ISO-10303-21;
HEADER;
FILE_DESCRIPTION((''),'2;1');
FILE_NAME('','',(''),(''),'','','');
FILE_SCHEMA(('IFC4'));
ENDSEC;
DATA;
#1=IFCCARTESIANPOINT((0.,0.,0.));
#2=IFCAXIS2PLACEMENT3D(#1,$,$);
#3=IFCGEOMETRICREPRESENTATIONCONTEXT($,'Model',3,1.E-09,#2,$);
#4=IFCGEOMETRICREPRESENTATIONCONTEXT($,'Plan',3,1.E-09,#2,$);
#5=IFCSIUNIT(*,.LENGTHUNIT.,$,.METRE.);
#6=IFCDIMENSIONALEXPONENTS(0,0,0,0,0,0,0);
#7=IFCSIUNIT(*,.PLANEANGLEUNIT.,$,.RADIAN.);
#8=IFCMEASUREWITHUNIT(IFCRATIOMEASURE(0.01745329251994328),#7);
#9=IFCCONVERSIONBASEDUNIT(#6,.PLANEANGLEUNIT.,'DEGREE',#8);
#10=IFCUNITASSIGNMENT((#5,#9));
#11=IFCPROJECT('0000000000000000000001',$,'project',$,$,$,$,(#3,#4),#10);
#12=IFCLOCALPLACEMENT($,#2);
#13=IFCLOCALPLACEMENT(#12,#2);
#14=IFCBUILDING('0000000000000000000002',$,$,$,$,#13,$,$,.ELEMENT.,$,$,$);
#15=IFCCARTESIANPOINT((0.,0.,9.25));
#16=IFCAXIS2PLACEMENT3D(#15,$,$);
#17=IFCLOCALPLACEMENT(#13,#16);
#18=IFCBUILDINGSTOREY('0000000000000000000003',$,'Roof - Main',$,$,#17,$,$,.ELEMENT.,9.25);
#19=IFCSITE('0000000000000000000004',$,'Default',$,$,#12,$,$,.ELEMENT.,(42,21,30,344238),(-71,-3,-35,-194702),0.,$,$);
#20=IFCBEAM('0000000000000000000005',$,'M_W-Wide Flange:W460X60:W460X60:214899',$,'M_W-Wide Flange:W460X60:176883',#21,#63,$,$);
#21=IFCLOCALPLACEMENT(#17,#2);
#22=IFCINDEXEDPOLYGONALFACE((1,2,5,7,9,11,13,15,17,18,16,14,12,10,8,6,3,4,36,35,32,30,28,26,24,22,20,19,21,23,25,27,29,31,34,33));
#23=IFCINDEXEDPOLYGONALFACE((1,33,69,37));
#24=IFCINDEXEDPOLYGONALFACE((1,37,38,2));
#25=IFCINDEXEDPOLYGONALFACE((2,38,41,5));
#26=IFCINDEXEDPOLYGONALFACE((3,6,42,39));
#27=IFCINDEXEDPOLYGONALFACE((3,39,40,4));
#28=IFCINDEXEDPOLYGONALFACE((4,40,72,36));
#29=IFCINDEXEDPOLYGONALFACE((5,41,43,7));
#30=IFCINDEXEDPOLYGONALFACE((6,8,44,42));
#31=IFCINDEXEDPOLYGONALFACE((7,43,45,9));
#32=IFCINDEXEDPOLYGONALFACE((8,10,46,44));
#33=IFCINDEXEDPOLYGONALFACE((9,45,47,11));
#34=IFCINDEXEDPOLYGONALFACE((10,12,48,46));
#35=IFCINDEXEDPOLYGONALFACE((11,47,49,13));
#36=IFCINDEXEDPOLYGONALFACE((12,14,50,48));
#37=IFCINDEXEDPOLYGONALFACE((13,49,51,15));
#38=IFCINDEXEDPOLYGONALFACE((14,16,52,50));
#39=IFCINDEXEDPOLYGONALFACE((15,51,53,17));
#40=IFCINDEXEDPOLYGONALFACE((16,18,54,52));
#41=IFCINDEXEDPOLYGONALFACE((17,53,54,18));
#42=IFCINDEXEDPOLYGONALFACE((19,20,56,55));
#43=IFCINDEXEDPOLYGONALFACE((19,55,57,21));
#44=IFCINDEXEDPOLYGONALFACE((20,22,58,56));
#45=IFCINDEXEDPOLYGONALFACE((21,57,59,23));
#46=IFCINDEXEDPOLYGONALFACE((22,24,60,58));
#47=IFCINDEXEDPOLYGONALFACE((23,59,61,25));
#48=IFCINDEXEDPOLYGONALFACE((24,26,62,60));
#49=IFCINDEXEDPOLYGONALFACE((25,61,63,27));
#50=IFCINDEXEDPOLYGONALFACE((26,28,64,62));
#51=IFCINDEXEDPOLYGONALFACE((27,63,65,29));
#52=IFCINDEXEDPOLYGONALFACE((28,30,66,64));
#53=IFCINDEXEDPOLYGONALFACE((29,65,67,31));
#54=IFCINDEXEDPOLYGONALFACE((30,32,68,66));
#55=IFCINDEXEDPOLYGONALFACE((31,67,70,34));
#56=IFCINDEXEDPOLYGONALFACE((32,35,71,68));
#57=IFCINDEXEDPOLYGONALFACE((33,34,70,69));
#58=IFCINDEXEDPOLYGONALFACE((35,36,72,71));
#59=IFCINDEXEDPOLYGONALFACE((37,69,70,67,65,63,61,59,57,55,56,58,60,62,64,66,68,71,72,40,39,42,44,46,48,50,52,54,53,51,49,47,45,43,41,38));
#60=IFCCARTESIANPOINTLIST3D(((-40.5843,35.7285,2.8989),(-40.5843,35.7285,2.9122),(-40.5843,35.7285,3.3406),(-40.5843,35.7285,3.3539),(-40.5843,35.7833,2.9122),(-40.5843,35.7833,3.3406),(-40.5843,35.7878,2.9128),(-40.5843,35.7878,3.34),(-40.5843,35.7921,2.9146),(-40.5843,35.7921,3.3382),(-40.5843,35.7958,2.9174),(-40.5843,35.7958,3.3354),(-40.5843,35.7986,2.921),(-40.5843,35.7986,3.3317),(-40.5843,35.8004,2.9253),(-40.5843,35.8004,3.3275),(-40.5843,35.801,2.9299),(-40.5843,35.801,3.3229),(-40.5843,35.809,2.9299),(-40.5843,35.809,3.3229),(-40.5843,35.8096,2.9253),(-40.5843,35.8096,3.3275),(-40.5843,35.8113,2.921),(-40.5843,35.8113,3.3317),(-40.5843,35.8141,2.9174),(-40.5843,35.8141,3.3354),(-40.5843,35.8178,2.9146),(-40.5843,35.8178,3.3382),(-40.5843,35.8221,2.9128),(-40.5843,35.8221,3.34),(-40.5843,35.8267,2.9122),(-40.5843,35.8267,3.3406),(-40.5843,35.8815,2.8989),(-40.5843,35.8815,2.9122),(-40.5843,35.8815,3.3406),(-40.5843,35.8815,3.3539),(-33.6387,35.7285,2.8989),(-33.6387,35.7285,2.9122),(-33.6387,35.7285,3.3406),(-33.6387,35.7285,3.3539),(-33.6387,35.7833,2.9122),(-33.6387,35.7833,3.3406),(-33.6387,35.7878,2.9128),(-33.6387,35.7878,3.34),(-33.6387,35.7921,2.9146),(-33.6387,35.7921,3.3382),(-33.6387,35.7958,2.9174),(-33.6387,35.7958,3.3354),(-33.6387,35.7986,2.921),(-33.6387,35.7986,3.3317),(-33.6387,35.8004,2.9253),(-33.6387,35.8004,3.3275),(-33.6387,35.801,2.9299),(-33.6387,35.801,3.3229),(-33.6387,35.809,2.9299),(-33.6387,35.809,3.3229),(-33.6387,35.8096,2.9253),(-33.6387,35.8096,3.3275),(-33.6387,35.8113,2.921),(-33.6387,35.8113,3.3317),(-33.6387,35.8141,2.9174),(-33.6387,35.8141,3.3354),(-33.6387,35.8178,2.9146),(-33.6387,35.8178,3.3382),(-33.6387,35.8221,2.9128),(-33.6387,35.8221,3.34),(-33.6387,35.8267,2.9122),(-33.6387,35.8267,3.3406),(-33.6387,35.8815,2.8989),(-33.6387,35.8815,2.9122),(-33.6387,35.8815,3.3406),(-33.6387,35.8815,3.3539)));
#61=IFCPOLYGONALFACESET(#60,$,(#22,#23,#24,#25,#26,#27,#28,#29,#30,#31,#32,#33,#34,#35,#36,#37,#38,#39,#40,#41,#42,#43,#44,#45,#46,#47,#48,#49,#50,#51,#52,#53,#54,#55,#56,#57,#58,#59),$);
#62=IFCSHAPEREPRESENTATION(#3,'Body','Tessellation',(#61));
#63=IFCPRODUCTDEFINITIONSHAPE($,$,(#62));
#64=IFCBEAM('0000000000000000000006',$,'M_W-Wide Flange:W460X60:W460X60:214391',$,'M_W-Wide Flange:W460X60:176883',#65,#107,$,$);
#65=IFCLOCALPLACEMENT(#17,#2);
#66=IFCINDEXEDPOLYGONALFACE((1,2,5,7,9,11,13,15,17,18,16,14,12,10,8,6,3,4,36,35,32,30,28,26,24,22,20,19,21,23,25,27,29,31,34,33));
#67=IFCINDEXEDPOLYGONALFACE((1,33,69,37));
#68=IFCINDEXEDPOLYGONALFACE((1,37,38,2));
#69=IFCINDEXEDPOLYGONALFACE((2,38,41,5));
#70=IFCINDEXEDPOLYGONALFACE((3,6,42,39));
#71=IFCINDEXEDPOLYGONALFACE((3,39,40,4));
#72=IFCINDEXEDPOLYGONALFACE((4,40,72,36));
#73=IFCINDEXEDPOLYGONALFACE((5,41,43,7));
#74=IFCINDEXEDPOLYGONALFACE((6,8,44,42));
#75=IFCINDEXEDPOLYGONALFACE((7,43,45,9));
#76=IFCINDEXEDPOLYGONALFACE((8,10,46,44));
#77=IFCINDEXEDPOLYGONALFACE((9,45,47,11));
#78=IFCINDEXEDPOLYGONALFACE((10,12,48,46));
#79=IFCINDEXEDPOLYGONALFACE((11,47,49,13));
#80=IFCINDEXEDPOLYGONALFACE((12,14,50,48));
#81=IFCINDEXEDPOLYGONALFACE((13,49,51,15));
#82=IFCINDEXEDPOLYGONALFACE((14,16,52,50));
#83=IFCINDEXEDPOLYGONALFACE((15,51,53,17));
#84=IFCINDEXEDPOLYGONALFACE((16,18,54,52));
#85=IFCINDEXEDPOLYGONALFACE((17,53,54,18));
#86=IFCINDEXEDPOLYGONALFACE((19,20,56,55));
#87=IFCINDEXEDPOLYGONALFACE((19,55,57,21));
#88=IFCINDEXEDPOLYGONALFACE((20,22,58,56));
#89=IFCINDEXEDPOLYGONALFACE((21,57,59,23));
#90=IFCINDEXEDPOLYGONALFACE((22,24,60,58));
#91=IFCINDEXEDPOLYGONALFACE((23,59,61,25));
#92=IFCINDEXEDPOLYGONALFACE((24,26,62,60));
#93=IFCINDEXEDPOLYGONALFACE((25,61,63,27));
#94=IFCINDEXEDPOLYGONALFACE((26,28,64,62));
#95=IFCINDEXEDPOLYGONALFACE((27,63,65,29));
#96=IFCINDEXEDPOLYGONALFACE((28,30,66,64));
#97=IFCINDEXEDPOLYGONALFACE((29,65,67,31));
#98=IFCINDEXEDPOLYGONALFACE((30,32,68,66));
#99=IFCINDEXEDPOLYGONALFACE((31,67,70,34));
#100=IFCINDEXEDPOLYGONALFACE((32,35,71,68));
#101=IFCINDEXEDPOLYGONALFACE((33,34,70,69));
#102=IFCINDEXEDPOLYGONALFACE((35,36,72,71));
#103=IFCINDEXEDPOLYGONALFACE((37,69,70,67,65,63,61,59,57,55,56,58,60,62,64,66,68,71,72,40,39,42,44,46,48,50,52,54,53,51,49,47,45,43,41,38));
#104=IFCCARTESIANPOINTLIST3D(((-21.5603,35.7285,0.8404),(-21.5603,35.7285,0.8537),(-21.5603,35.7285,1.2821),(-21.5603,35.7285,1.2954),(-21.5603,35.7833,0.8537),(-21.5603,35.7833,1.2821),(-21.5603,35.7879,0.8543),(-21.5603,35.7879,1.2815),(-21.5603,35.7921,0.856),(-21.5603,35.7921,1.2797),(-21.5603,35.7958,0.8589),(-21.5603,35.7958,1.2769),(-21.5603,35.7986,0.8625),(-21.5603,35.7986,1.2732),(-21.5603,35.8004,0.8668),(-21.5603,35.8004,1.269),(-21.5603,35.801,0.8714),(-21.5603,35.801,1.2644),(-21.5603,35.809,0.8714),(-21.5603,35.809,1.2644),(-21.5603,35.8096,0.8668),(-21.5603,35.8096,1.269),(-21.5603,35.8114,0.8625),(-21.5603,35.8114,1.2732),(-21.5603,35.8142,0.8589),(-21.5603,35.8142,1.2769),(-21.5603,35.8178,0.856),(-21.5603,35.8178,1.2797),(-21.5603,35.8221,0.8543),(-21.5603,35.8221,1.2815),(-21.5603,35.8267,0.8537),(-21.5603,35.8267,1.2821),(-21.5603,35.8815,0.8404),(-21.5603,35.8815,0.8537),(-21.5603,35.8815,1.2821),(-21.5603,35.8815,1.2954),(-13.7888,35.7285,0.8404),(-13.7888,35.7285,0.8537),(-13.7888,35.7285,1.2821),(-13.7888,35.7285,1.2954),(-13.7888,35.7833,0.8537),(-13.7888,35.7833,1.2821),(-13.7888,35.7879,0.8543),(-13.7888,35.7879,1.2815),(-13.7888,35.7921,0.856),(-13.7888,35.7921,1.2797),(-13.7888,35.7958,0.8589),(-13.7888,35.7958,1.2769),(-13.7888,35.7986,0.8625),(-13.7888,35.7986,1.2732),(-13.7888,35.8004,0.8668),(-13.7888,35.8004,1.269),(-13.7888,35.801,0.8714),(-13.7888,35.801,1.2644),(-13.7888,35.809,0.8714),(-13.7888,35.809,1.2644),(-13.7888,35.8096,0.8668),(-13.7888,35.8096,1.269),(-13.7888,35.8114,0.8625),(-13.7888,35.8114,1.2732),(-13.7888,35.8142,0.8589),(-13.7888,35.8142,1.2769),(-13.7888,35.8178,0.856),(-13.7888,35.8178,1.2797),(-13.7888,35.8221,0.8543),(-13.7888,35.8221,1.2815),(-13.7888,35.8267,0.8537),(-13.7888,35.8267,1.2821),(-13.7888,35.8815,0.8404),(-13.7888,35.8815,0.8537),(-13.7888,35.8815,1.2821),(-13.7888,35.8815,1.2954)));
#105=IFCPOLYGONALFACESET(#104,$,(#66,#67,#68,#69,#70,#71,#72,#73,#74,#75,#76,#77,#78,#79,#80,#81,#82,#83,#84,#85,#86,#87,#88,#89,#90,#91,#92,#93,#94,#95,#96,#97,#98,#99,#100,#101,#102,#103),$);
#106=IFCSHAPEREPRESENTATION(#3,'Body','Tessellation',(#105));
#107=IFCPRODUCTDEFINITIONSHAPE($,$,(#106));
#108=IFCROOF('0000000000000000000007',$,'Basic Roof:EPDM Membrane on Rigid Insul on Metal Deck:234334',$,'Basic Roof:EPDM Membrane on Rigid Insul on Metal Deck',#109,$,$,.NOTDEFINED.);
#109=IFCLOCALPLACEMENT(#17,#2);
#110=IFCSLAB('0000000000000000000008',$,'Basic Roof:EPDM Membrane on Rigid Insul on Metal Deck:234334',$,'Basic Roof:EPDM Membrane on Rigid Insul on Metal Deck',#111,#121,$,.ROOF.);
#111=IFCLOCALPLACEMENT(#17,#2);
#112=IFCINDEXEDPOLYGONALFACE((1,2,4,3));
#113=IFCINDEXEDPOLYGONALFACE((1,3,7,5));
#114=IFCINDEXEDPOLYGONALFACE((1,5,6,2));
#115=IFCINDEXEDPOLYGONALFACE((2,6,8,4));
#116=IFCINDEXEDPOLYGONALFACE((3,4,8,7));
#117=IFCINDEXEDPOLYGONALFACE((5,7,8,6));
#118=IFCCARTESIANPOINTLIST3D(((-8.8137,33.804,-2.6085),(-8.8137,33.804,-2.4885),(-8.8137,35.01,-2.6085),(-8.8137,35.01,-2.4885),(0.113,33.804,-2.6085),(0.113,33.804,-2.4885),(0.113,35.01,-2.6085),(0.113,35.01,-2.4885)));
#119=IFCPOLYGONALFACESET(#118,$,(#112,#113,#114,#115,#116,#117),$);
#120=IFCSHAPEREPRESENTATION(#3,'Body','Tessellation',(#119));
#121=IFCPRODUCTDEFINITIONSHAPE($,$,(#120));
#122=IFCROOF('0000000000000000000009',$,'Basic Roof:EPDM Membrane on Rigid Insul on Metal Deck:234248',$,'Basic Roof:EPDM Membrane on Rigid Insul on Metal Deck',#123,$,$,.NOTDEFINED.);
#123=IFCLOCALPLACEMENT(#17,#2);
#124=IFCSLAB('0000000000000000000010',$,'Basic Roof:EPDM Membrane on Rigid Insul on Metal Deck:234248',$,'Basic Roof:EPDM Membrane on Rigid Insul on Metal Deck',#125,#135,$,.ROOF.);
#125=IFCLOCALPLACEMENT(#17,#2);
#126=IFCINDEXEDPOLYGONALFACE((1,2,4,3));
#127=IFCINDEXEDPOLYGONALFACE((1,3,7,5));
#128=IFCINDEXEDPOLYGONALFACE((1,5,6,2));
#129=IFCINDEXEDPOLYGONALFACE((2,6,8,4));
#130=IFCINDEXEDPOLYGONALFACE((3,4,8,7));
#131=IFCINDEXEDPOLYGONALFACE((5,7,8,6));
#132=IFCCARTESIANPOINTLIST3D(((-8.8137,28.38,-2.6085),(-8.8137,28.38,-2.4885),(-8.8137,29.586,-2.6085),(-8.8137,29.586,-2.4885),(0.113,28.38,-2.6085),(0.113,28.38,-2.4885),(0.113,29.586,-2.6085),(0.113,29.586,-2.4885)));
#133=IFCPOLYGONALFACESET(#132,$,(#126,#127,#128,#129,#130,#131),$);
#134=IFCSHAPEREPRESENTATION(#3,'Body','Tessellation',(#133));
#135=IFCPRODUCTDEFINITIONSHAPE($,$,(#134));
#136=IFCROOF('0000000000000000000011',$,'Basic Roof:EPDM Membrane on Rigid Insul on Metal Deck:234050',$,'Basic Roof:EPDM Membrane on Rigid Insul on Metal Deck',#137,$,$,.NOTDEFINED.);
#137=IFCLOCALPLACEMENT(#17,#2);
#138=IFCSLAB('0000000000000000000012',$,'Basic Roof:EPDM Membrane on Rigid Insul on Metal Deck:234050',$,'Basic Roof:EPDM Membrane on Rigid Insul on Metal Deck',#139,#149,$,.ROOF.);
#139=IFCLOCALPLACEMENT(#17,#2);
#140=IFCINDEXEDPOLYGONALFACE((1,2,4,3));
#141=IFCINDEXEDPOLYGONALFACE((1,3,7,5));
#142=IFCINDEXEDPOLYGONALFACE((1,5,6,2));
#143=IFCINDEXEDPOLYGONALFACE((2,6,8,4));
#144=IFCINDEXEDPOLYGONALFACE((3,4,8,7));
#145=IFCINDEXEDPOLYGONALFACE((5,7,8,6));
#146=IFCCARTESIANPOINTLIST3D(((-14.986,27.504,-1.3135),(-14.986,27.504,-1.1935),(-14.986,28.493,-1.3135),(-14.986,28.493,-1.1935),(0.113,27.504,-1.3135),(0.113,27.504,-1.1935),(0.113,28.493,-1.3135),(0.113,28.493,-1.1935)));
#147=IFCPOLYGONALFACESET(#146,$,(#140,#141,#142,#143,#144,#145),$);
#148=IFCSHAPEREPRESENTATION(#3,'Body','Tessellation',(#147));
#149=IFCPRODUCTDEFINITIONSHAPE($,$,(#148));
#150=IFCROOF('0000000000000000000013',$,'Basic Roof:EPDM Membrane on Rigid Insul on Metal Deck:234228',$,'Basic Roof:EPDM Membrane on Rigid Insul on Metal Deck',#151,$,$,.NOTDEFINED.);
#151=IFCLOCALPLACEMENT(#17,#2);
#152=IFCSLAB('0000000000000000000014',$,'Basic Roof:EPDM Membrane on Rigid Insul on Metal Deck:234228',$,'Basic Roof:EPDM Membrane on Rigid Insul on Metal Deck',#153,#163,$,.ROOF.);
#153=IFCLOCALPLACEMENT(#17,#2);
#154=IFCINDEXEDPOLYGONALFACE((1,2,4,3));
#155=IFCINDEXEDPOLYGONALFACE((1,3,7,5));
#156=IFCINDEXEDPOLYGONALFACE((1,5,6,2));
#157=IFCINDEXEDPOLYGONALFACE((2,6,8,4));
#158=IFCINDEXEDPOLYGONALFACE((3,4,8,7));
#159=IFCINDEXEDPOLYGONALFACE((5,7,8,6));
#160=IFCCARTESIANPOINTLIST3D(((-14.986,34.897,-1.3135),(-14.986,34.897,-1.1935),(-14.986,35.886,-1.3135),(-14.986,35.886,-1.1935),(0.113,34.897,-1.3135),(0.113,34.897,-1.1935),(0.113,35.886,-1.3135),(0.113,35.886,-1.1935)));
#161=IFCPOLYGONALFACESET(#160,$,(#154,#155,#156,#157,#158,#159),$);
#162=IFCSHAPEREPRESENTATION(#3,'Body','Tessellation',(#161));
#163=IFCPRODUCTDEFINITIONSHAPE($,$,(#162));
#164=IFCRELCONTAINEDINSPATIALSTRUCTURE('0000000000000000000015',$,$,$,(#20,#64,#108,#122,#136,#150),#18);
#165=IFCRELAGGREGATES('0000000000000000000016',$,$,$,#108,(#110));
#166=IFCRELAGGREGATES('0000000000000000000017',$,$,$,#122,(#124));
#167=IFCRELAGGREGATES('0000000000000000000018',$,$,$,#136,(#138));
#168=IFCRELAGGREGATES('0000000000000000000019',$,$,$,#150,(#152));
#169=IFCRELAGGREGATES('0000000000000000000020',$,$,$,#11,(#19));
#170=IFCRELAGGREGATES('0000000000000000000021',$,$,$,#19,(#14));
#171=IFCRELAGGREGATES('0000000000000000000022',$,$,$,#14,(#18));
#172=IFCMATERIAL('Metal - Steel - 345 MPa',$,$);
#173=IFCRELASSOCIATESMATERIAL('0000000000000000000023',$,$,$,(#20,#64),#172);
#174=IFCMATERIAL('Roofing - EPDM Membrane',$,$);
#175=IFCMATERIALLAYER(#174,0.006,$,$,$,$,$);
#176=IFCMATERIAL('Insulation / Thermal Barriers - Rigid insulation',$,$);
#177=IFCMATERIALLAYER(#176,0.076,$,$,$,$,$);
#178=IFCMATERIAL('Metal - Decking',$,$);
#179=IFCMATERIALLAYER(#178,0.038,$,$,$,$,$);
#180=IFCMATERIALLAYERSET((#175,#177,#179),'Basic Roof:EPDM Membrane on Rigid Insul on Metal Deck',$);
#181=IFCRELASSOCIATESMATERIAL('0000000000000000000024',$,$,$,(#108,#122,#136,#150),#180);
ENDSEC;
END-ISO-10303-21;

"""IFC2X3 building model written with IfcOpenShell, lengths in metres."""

from ifc_helpers import new_model, entity, si_unit, converted_unit, frame, frame_2d, origin, origin_2d_with_axis, place, context, project, spatial, polyline, circle_curve, parameter, trimmed, segment, composite_curve, rectangle, outline, extrude, material, layer, layer_set, layer_usage, element, aggregate, save


model = new_model("IFC2X3")

# Units and contexts
model_context = context("Model", 3, precision=1e-09, world=origin())
plan_context = context("Plan", 3, precision=1e-09, world=origin())
ifc_project = project(units=[si_unit("LENGTHUNIT", "METRE"), converted_unit("PLANEANGLEUNIT", "DEGREE", entity("IfcRatioMeasure", 0.01745329251994328), si_unit("PLANEANGLEUNIT", "RADIAN"), dimensions=[0, 0, 0, 0, 0, 0, 0])], contexts=[model_context, plan_context])

# Site, building, storey
site_placement = place(None, origin())
site = spatial("IfcSite", under=ifc_project, at=site_placement, Name="Default", CompositionType="ELEMENT", RefLatitude=(42, 21, 30, 344238), RefLongitude=(-71, -3, -35, -194702), RefElevation=0.0)
building_placement = place(site_placement, origin())
building = spatial("IfcBuilding", under=site, at=building_placement, CompositionType="ELEMENT")
storey_placement = place(building_placement, frame((0.0, 0.0, 9.25)))
storey = spatial("IfcBuildingStorey", under=building, at=storey_placement, Name="Roof - Main", CompositionType="ELEMENT", Elevation=9.25)

# Shared definitions
ifc_material_1 = material(Name="Metal - Steel - 345 MPa")

# Beams
beam_1_placement = place(storey_placement, frame((-6.691, 35.805, 3.3539), z_axis=(0.0, 0.0, 1.0), x_axis=(0.0, -1.0, 0.0)))
element("IfcBeam", 1, at=beam_1_placement, inside=storey, material=ifc_material_1, Name="M_W-Wide Flange:W460X60:W460X60:214899", ObjectType="M_W-Wide Flange:W460X60:176883", context=model_context, shape_type="SweptSolid", body=[
    extrude(outline(composite_curve([segment(polyline([(-0.0765, -0.2142), (-0.0765, -0.2275)]), True, "CONTINUOUS"), segment(polyline([(-0.0765, -0.2275), (0.0765, -0.2275)]), True, "CONTINUOUS"), segment(polyline([(0.0765, -0.2275), (0.0765, -0.2142)]), True, "CONTINUOUS"), segment(polyline([(0.0765, -0.2142), (0.0217, -0.2142)]), True, "CONTINUOUS"), segment(trimmed(circle_curve(frame_2d((0.0217, -0.1965), x_axis=(1.0, 0.0)), 0.0177), [parameter(180.0)], [parameter(270.0)], True, "PARAMETER"), False, "CONTINUOUS"), segment(polyline([(0.004, -0.1965), (0.004, 0.1965)]), True, "CONTINUOUS"), segment(trimmed(circle_curve(frame_2d((0.0217, 0.1965), x_axis=(1.0, 0.0)), 0.0177), [parameter(90.0)], [parameter(180.0)], True, "PARAMETER"), False, "CONTINUOUS"), segment(polyline([(0.0217, 0.2142), (0.0765, 0.2142)]), True, "CONTINUOUS"), segment(polyline([(0.0765, 0.2142), (0.0765, 0.2275)]), True, "CONTINUOUS"), segment(polyline([(0.0765, 0.2275), (-0.0765, 0.2275)]), True, "CONTINUOUS"), segment(polyline([(-0.0765, 0.2275), (-0.0765, 0.2142)]), True, "CONTINUOUS"), segment(polyline([(-0.0765, 0.2142), (-0.0217, 0.2142)]), True, "CONTINUOUS"), segment(trimmed(circle_curve(frame_2d((-0.0217, 0.1965), x_axis=(1.0, 0.0)), 0.0177), [parameter(360.0)], [parameter(90.0)], True, "PARAMETER"), False, "CONTINUOUS"), segment(polyline([(-0.004, 0.1965), (-0.004, -0.1965)]), True, "CONTINUOUS"), segment(trimmed(circle_curve(frame_2d((-0.0217, -0.1965), x_axis=(1.0, 0.0)), 0.0177), [parameter(270.0)], [parameter(0.0)], True, "PARAMETER"), False, "CONTINUOUS"), segment(polyline([(-0.0217, -0.2142), (-0.0765, -0.2142)]), True, "CONTINUOUS")], self_intersect=False)), frame((0.0, -33.8933, -0.2275), z_axis=(0.0, -1.0, 0.0), x_axis=(1.0, 0.0, 0.0)), (0.0, 0.0, -1.0), 6.9456),
])
beam_2_placement = place(storey_placement, frame((-7.2776, 35.805, 1.2954), z_axis=(0.0, 0.0, 1.0), x_axis=(0.0, -1.0, 0.0)))
element("IfcBeam", 2, at=beam_2_placement, inside=storey, material=ifc_material_1, Name="M_W-Wide Flange:W460X60:W460X60:214391", ObjectType="M_W-Wide Flange:W460X60:176883", context=model_context, shape_type="SweptSolid", body=[
    extrude(outline(composite_curve([segment(polyline([(-0.0765, -0.2142), (-0.0765, -0.2275)]), True, "CONTINUOUS"), segment(polyline([(-0.0765, -0.2275), (0.0765, -0.2275)]), True, "CONTINUOUS"), segment(polyline([(0.0765, -0.2275), (0.0765, -0.2142)]), True, "CONTINUOUS"), segment(polyline([(0.0765, -0.2142), (0.0217, -0.2142)]), True, "CONTINUOUS"), segment(trimmed(circle_curve(frame_2d((0.0217, -0.1965), x_axis=(1.0, 0.0)), 0.0177), [parameter(180.0)], [parameter(270.0)], True, "PARAMETER"), False, "CONTINUOUS"), segment(polyline([(0.004, -0.1965), (0.004, 0.1965)]), True, "CONTINUOUS"), segment(trimmed(circle_curve(frame_2d((0.0217, 0.1965), x_axis=(1.0, 0.0)), 0.0177), [parameter(90.0)], [parameter(180.0)], True, "PARAMETER"), False, "CONTINUOUS"), segment(polyline([(0.0217, 0.2142), (0.0765, 0.2142)]), True, "CONTINUOUS"), segment(polyline([(0.0765, 0.2142), (0.0765, 0.2275)]), True, "CONTINUOUS"), segment(polyline([(0.0765, 0.2275), (-0.0765, 0.2275)]), True, "CONTINUOUS"), segment(polyline([(-0.0765, 0.2275), (-0.0765, 0.2142)]), True, "CONTINUOUS"), segment(polyline([(-0.0765, 0.2142), (-0.0217, 0.2142)]), True, "CONTINUOUS"), segment(trimmed(circle_curve(frame_2d((-0.0217, 0.1965), x_axis=(1.0, 0.0)), 0.0177), [parameter(360.0)], [parameter(90.0)], True, "PARAMETER"), False, "CONTINUOUS"), segment(polyline([(-0.004, 0.1965), (-0.004, -0.1965)]), True, "CONTINUOUS"), segment(trimmed(circle_curve(frame_2d((-0.0217, -0.1965), x_axis=(1.0, 0.0)), 0.0177), [parameter(270.0)], [parameter(0.0)], True, "PARAMETER"), False, "CONTINUOUS"), segment(polyline([(-0.0217, -0.2142), (-0.0765, -0.2142)]), True, "CONTINUOUS")], self_intersect=False)), frame((0.0, -14.2827, -0.2275), z_axis=(0.0, -1.0, 0.0), x_axis=(1.0, 0.0, 0.0)), (0.0, 0.0, -1.0), 7.7715),
])

# Shared definitions
ifc_material_2 = material(Name="Metal - Decking")

# Roofs, slabs
ifc_material_3 = material(Name="Roofing - EPDM Membrane")
ifc_layer_1 = layer(ifc_material_3, 0.006)
ifc_material_4 = material(Name="Insulation / Thermal Barriers - Rigid insulation")
ifc_layer_2 = layer(ifc_material_4, 0.076)
ifc_layer_3 = layer(ifc_material_2, 0.038)
ifc_layer_set_1 = layer_set([ifc_layer_1, ifc_layer_2, ifc_layer_3], Name="Basic Roof:EPDM Membrane on Rigid Insul on Metal Deck")
ifc_layer_usage_1 = layer_usage(ifc_layer_set_1, "AXIS3", "NEGATIVE", 0.0)
roof_1_placement = place(storey_placement, origin())
roof_1 = element("IfcRoof", 3, at=roof_1_placement, inside=storey, material=ifc_layer_usage_1, Name="Basic Roof:EPDM Membrane on Rigid Insul on Metal Deck:234334", ObjectType="Basic Roof:EPDM Membrane on Rigid Insul on Metal Deck", ShapeType="NOTDEFINED")
slab_1_placement = place(roof_1_placement, frame((-8.8137, 33.804, -2.6085)))
slab_1 = element("IfcSlab", 4, at=slab_1_placement, Name="Basic Roof:EPDM Membrane on Rigid Insul on Metal Deck:234334", ObjectType="Basic Roof:EPDM Membrane on Rigid Insul on Metal Deck", PredefinedType="ROOF", context=model_context, shape_type="SweptSolid", body=[
    extrude(rectangle(XDim=8.9267, YDim=1.206, at=frame_2d((0.0, 0.0), x_axis=(-1.0, 0.0))), frame((4.4634, 0.603, 0.0)), (0.0, 0.0, 1.0), 0.12),
])
aggregate(roof_1, [slab_1])
roof_2_placement = place(storey_placement, origin())
roof_2 = element("IfcRoof", 5, at=roof_2_placement, inside=storey, material=ifc_layer_usage_1, Name="Basic Roof:EPDM Membrane on Rigid Insul on Metal Deck:234248", ObjectType="Basic Roof:EPDM Membrane on Rigid Insul on Metal Deck", ShapeType="NOTDEFINED")
slab_2_placement = place(roof_2_placement, frame((-8.8137, 28.38, -2.6085)))
slab_2 = element("IfcSlab", 6, at=slab_2_placement, Name="Basic Roof:EPDM Membrane on Rigid Insul on Metal Deck:234248", ObjectType="Basic Roof:EPDM Membrane on Rigid Insul on Metal Deck", PredefinedType="ROOF", context=model_context, shape_type="SweptSolid", body=[
    extrude(rectangle(XDim=8.9267, YDim=1.206, at=origin_2d_with_axis()), frame((4.4634, 0.603, 0.0)), (0.0, 0.0, 1.0), 0.12),
])
aggregate(roof_2, [slab_2])
roof_3_placement = place(storey_placement, origin())
roof_3 = element("IfcRoof", 7, at=roof_3_placement, inside=storey, material=ifc_layer_usage_1, Name="Basic Roof:EPDM Membrane on Rigid Insul on Metal Deck:234050", ObjectType="Basic Roof:EPDM Membrane on Rigid Insul on Metal Deck", ShapeType="NOTDEFINED")
slab_3_placement = place(roof_3_placement, frame((-14.986, 27.504, -1.3135)))
slab_3 = element("IfcSlab", 8, at=slab_3_placement, Name="Basic Roof:EPDM Membrane on Rigid Insul on Metal Deck:234050", ObjectType="Basic Roof:EPDM Membrane on Rigid Insul on Metal Deck", PredefinedType="ROOF", context=model_context, shape_type="SweptSolid", body=[
    extrude(rectangle(XDim=15.099, YDim=0.989, at=origin_2d_with_axis()), frame((7.5495, 0.4945, 0.0)), (0.0, 0.0, 1.0), 0.12),
])
aggregate(roof_3, [slab_3])
roof_4_placement = place(storey_placement, origin())
roof_4 = element("IfcRoof", 9, at=roof_4_placement, inside=storey, material=ifc_layer_usage_1, Name="Basic Roof:EPDM Membrane on Rigid Insul on Metal Deck:234228", ObjectType="Basic Roof:EPDM Membrane on Rigid Insul on Metal Deck", ShapeType="NOTDEFINED")
slab_4_placement = place(roof_4_placement, frame((-14.986, 34.897, -1.3135)))
slab_4 = element("IfcSlab", 10, at=slab_4_placement, Name="Basic Roof:EPDM Membrane on Rigid Insul on Metal Deck:234228", ObjectType="Basic Roof:EPDM Membrane on Rigid Insul on Metal Deck", PredefinedType="ROOF", context=model_context, shape_type="SweptSolid", body=[
    extrude(rectangle(XDim=15.099, YDim=0.989, at=frame_2d((0.0, 0.0), x_axis=(-1.0, 0.0))), frame((7.5495, 0.4945, 0.0)), (0.0, 0.0, 1.0), 0.12),
])
aggregate(roof_4, [slab_4])

save(model, "model.ifc")
